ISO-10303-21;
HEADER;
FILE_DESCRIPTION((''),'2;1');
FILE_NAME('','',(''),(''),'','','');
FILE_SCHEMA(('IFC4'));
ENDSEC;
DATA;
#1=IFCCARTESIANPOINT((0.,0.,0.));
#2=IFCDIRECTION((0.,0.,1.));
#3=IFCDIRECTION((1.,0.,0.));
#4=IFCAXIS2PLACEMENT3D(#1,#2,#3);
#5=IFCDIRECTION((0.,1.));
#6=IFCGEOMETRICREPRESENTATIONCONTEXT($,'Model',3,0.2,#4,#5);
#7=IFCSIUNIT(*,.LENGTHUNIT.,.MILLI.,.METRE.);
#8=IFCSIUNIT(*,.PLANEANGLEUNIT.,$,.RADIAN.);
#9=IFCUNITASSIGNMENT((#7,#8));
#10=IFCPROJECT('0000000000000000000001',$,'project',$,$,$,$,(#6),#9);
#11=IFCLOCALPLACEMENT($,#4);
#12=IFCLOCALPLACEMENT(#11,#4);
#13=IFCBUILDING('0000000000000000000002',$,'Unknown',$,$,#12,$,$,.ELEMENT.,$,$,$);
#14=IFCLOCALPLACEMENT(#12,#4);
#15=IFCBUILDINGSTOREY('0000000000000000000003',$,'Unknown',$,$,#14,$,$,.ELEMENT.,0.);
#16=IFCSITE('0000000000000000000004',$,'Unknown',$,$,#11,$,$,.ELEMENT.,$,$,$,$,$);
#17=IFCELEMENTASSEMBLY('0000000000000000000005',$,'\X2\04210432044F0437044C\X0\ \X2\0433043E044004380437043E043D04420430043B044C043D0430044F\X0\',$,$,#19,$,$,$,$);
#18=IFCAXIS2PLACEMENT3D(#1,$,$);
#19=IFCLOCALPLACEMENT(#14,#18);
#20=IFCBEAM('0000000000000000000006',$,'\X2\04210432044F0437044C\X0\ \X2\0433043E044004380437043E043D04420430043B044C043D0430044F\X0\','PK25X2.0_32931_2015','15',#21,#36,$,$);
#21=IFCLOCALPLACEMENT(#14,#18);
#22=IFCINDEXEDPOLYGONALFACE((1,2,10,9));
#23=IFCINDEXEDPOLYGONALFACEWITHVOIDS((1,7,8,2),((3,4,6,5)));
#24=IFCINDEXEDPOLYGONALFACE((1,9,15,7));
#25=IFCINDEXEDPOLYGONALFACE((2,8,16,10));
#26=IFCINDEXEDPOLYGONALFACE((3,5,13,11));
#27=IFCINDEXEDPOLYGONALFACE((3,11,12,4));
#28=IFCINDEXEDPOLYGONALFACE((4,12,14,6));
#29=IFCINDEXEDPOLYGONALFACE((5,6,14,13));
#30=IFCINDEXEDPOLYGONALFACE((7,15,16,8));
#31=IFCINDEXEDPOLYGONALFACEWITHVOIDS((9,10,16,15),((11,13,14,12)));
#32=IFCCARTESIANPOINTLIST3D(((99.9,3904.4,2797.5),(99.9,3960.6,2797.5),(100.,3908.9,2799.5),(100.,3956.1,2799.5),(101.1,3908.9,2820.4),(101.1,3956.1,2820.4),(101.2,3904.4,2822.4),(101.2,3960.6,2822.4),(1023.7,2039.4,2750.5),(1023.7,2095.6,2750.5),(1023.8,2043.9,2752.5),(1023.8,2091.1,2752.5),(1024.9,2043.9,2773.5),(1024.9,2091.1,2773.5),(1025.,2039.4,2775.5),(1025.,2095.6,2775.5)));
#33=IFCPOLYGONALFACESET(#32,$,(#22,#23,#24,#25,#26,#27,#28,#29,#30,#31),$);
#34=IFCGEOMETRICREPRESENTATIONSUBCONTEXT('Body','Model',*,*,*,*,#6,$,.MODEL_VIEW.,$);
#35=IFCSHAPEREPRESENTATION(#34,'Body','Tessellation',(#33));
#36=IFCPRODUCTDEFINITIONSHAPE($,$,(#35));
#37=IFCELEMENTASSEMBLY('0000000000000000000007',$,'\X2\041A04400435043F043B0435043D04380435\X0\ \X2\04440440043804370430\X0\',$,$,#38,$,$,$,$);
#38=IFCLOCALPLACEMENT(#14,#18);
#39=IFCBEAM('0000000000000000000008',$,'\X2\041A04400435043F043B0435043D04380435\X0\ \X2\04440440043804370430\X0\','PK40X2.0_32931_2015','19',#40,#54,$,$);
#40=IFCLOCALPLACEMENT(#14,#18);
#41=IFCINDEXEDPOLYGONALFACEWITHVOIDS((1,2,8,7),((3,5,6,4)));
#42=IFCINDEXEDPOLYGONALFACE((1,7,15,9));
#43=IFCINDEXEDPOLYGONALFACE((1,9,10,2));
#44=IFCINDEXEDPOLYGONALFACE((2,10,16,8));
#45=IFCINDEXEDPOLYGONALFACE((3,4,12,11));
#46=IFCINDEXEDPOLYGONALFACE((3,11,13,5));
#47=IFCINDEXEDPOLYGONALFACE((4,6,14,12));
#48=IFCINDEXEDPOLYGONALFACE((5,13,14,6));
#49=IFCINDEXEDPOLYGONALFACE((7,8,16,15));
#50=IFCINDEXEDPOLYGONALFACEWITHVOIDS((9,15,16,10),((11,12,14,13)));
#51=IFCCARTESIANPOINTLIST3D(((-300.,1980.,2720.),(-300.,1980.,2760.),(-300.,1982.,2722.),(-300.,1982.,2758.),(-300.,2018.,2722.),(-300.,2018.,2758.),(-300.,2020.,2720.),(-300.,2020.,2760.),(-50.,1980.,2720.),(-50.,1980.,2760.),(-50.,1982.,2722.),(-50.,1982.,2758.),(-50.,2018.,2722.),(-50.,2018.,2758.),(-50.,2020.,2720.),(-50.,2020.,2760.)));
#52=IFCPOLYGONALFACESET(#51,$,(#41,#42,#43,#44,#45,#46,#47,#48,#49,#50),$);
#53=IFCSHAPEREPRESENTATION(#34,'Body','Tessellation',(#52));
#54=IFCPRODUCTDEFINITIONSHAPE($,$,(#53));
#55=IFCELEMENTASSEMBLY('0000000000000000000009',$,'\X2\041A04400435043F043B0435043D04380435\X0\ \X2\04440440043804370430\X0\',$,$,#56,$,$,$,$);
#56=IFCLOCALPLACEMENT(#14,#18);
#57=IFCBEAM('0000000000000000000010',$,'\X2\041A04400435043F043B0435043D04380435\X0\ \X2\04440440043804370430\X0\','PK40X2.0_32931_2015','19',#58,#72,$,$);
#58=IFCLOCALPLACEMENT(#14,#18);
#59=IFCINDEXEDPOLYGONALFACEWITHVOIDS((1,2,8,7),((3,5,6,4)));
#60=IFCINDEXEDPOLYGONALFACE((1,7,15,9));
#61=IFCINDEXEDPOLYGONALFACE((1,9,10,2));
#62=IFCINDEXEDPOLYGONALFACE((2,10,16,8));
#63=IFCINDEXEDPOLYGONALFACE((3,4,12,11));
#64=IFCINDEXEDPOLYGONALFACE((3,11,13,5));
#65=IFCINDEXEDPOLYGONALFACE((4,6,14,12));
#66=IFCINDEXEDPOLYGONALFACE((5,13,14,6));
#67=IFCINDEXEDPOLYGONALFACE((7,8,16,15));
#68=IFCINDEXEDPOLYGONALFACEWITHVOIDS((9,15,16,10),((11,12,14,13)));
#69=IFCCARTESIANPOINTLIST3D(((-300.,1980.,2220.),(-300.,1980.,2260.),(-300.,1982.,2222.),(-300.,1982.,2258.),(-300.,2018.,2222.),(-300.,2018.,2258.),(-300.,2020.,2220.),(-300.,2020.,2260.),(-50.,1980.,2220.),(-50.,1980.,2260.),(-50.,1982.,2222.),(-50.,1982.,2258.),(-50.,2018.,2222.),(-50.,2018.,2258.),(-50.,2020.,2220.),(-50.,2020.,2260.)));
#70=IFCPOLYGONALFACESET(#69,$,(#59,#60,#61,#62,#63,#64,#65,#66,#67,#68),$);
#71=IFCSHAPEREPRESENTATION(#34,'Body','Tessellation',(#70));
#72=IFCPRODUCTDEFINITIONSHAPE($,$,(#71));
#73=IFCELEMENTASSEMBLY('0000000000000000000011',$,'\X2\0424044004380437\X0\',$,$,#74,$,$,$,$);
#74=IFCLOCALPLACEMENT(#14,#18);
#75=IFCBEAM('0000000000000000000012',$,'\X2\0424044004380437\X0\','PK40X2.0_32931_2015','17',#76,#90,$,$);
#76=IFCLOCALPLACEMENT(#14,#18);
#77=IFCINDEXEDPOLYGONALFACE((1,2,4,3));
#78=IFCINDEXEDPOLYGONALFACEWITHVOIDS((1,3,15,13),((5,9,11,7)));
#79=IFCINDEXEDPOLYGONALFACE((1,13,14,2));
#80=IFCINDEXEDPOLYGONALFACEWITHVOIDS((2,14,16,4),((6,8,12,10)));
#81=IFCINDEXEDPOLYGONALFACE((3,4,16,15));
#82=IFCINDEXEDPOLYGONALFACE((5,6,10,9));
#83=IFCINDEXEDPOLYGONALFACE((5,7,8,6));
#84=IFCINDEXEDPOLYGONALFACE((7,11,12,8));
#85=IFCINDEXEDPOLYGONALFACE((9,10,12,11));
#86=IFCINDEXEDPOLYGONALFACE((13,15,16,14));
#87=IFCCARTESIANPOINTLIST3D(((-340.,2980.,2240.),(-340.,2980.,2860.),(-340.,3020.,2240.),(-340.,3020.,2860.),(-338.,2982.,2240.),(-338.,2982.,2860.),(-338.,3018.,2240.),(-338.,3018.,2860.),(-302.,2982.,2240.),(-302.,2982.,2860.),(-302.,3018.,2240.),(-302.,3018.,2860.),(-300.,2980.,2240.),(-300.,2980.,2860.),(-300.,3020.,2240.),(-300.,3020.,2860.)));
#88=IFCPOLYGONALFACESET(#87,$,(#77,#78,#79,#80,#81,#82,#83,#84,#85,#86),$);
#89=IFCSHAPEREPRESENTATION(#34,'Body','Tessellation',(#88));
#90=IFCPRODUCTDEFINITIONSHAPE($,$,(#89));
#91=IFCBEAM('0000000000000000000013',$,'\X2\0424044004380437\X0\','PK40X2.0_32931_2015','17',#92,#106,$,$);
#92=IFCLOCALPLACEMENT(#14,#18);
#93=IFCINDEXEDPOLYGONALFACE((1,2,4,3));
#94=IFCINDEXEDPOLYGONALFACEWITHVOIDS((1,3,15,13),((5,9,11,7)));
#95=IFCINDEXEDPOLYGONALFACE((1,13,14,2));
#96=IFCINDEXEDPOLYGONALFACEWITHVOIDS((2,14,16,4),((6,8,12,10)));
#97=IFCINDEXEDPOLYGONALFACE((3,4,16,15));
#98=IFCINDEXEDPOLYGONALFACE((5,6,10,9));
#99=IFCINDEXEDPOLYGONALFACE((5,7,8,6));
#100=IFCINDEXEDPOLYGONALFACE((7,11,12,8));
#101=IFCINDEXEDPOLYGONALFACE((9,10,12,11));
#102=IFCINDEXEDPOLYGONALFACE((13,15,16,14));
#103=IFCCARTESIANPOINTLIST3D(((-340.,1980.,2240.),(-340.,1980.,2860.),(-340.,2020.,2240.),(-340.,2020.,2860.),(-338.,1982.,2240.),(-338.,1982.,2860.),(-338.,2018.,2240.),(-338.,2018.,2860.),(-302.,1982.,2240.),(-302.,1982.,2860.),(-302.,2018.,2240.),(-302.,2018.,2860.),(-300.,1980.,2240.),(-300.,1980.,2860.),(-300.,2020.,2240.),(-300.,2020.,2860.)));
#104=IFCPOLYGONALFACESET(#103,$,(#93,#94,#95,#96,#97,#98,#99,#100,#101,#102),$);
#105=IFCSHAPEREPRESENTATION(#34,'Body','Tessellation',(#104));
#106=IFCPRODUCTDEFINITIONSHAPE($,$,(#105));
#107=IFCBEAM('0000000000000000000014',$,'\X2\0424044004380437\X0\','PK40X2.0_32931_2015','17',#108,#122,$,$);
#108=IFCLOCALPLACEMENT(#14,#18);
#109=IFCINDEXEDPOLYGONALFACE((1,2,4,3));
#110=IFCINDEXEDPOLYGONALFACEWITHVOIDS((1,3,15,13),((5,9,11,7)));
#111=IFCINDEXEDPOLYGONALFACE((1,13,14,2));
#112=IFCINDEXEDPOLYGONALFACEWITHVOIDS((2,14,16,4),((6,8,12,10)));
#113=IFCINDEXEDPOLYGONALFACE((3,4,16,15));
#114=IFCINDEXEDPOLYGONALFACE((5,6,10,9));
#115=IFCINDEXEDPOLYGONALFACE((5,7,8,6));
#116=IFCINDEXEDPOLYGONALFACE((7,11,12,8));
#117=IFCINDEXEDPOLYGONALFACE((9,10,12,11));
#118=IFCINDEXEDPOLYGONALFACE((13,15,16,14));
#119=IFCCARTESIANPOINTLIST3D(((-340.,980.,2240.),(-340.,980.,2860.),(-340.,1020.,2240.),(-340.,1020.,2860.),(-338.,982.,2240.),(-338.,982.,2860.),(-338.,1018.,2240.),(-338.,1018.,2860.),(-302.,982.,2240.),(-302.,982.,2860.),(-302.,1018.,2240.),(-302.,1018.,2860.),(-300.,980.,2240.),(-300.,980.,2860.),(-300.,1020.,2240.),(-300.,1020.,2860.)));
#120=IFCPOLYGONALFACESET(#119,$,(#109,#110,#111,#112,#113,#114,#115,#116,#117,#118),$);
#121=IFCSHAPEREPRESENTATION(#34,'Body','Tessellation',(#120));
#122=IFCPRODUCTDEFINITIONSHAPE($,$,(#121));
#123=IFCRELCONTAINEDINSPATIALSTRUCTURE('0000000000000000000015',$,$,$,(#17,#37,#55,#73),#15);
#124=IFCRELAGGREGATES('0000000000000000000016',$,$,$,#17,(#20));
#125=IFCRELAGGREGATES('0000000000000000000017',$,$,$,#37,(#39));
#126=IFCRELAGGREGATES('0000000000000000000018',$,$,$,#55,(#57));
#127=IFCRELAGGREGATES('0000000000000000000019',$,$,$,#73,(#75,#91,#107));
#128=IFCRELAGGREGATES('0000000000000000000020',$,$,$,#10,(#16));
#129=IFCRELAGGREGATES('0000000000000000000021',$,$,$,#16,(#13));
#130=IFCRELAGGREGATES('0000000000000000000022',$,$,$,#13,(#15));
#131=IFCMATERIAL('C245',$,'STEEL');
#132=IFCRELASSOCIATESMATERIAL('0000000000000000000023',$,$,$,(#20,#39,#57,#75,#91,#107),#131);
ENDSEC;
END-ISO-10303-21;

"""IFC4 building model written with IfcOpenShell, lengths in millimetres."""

from ifc_helpers import new_model, si_unit, direction, frame, origin_with_axes, place, context, subcontext, project, spatial, line, indexed_curve, outline, extrude, material, element, aggregate, save


model = new_model("IFC4")

# Units and contexts
model_context = context("Model", 3, precision=0.2, world=origin_with_axes(), true_north=direction((0.0, 1.0)))
body_context = subcontext(model_context, "Body", "Model", "MODEL_VIEW")
ifc_project = project(units=[si_unit("LENGTHUNIT", "METRE", prefix="MILLI"), si_unit("PLANEANGLEUNIT", "RADIAN")], contexts=[model_context])

# Site, building, storey
site_placement = place(None, origin_with_axes())
site = spatial("IfcSite", under=ifc_project, at=site_placement, Name="Unknown", CompositionType="ELEMENT")
building_placement = place(site_placement, origin_with_axes())
building = spatial("IfcBuilding", under=site, at=building_placement, Name="Unknown", CompositionType="ELEMENT")
storey_placement = place(building_placement, origin_with_axes())
storey = spatial("IfcBuildingStorey", under=building, at=storey_placement, Name="Unknown", CompositionType="ELEMENT", Elevation=0.0)

# Shared definitions
ifc_material_1 = material(Name="C245", Category="STEEL")

# Element assembly, beam, voiding features
assembly_1_placement = place(storey_placement, frame((73.4, 3987.4, 2811.3), z_axis=(-0.894709, -0.444326, 0.045494), x_axis=(0.443753, -0.895865, -0.022564)))
assembly_1 = element("IfcElementAssembly", 1, at=assembly_1_placement, inside=storey, Name="Связь горизонтальная")
beam_1_placement = place(assembly_1_placement, origin_with_axes())
beam_1 = element("IfcBeam", 2, at=beam_1_placement, material=ifc_material_1, Name="Связь горизонтальная", Description="PK25X2.0_32931_2015", ObjectType="15", context=body_context, shape_type="SolidModel", body=[
    extrude(outline(indexed_curve([(-12.5, -12.5), (12.5, -12.5), (12.5, 12.5), (-12.5, 12.5)], segments=[line(1, 2, 3, 4, 1)]), holes=[indexed_curve([(-10.5, -10.5), (-10.5, 10.5), (10.5, 10.5), (10.5, -10.5)], segments=[line(1, 2, 3, 4, 1)])]), frame((0.0, 0.0, 0.0), z_axis=(-1.0, 0.0, 0.0), x_axis=(0.0, 0.0, 1.0)), (0.0, 0.0, -1.0), 2204.4),
])
voiding_feature_1_placement = place(beam_1_placement, frame((3193.8, 12.5, 493.2), z_axis=(0.444326, 0.0, -0.895865), x_axis=(-0.895865, 0.0, -0.444326)))
element("IfcVoidingFeature", 3, at=voiding_feature_1_placement, cuts=beam_1, Name="CUT_BEAM", ObjectType="(?)", PredefinedType="HOLE", context=body_context, shape_type="SolidModel", body=[
    extrude(outline(indexed_curve([(-25.0, -25.0), (25.0, -25.0), (25.0, 25.0), (-25.0, 25.0)], segments=[line(1, 2, 3, 4, 1)])), frame((0.0, 0.0, 0.0), z_axis=(-1.0, 0.0, 0.0), x_axis=(0.0, 0.0, 1.0)), (0.0, 0.0, -1.0), 2220.1),
])
voiding_feature_2_placement = place(beam_1_placement, frame((999.5, 12.5, 493.2), z_axis=(0.444326, 0.0, -0.895865), x_axis=(-0.895865, 0.0, -0.444326)))
element("IfcVoidingFeature", 4, at=voiding_feature_2_placement, cuts=beam_1, Name="CUT_BEAM", ObjectType="(?)", PredefinedType="HOLE", context=body_context, shape_type="SolidModel", body=[
    extrude(outline(indexed_curve([(-25.0, -25.0), (25.0, -25.0), (25.0, 25.0), (-25.0, 25.0)], segments=[line(1, 2, 3, 4, 1)])), frame((0.0, 0.0, 0.0), z_axis=(-1.0, 0.0, 0.0), x_axis=(0.0, 0.0, 1.0)), (0.0, 0.0, -1.0), 2220.1),
])
aggregate(assembly_1, [beam_1])

# Element assemblies, beams
assembly_2_placement = place(storey_placement, frame((-300.0, 2000.0, 2740.0), z_axis=(0.0, 1.0, 0.0), x_axis=(1.0, 0.0, 0.0)))
assembly_2 = element("IfcElementAssembly", 5, at=assembly_2_placement, inside=storey, Name="Крепление фриза")
beam_2_placement = place(assembly_2_placement, origin_with_axes())
beam_2 = element("IfcBeam", 6, at=beam_2_placement, material=ifc_material_1, Name="Крепление фриза", Description="PK40X2.0_32931_2015", ObjectType="19", context=body_context, shape_type="SolidModel", body=[
    extrude(outline(indexed_curve([(-20.0, -20.0), (20.0, -20.0), (20.0, 20.0), (-20.0, 20.0)], segments=[line(1, 2, 3, 4, 1)]), holes=[indexed_curve([(-18.0, -18.0), (-18.0, 18.0), (18.0, 18.0), (18.0, -18.0)], segments=[line(1, 2, 3, 4, 1)])]), frame((0.0, 0.0, 0.0), z_axis=(-1.0, 0.0, 0.0), x_axis=(0.0, 0.0, 1.0)), (0.0, 0.0, -1.0), 250.0),
])
aggregate(assembly_2, [beam_2])
assembly_3_placement = place(storey_placement, frame((-300.0, 2000.0, 2240.0), z_axis=(0.0, 1.0, 0.0), x_axis=(1.0, 0.0, 0.0)))
assembly_3 = element("IfcElementAssembly", 7, at=assembly_3_placement, inside=storey, Name="Крепление фриза")
beam_3_placement = place(assembly_3_placement, origin_with_axes())
beam_3 = element("IfcBeam", 8, at=beam_3_placement, material=ifc_material_1, Name="Крепление фриза", Description="PK40X2.0_32931_2015", ObjectType="19", context=body_context, shape_type="SolidModel", body=[
    extrude(outline(indexed_curve([(-20.0, -20.0), (20.0, -20.0), (20.0, 20.0), (-20.0, 20.0)], segments=[line(1, 2, 3, 4, 1)]), holes=[indexed_curve([(-18.0, -18.0), (-18.0, 18.0), (18.0, 18.0), (18.0, -18.0)], segments=[line(1, 2, 3, 4, 1)])]), frame((0.0, 0.0, 0.0), z_axis=(-1.0, 0.0, 0.0), x_axis=(0.0, 0.0, 1.0)), (0.0, 0.0, -1.0), 250.0),
])
aggregate(assembly_3, [beam_3])

# Element assembly, beams
assembly_4_placement = place(storey_placement, frame((-320.0, -300.0, 2880.0), z_axis=(1.0, 0.0, 0.0), x_axis=(0.0, 1.0, 0.0)))
assembly_4 = element("IfcElementAssembly", 9, at=assembly_4_placement, inside=storey, Name="Фриз")
beam_4_placement = place(assembly_4_placement, frame((3300.0, -20.0, 0.0), z_axis=(-1.0, 0.0, 0.0), x_axis=(0.0, -1.0, 0.0)))
beam_4 = element("IfcBeam", 10, at=beam_4_placement, material=ifc_material_1, Name="Фриз", Description="PK40X2.0_32931_2015", ObjectType="17", context=body_context, shape_type="SolidModel", body=[
    extrude(outline(indexed_curve([(-20.0, -20.0), (20.0, -20.0), (20.0, 20.0), (-20.0, 20.0)], segments=[line(1, 2, 3, 4, 1)]), holes=[indexed_curve([(-18.0, -18.0), (-18.0, 18.0), (18.0, 18.0), (18.0, -18.0)], segments=[line(1, 2, 3, 4, 1)])]), frame((0.0, 0.0, 0.0), z_axis=(-1.0, 0.0, 0.0), x_axis=(0.0, 0.0, 1.0)), (0.0, 0.0, -1.0), 620.0),
])
beam_5_placement = place(assembly_4_placement, frame((2300.0, -20.0, 0.0), z_axis=(-1.0, 0.0, 0.0), x_axis=(0.0, -1.0, 0.0)))
beam_5 = element("IfcBeam", 11, at=beam_5_placement, material=ifc_material_1, Name="Фриз", Description="PK40X2.0_32931_2015", ObjectType="17", context=body_context, shape_type="SolidModel", body=[
    extrude(outline(indexed_curve([(-20.0, -20.0), (20.0, -20.0), (20.0, 20.0), (-20.0, 20.0)], segments=[line(1, 2, 3, 4, 1)]), holes=[indexed_curve([(-18.0, -18.0), (-18.0, 18.0), (18.0, 18.0), (18.0, -18.0)], segments=[line(1, 2, 3, 4, 1)])]), frame((0.0, 0.0, 0.0), z_axis=(-1.0, 0.0, 0.0), x_axis=(0.0, 0.0, 1.0)), (0.0, 0.0, -1.0), 620.0),
])
beam_6_placement = place(assembly_4_placement, frame((1300.0, -20.0, 0.0), z_axis=(-1.0, 0.0, 0.0), x_axis=(0.0, -1.0, 0.0)))
beam_6 = element("IfcBeam", 12, at=beam_6_placement, material=ifc_material_1, Name="Фриз", Description="PK40X2.0_32931_2015", ObjectType="17", context=body_context, shape_type="SolidModel", body=[
    extrude(outline(indexed_curve([(-20.0, -20.0), (20.0, -20.0), (20.0, 20.0), (-20.0, 20.0)], segments=[line(1, 2, 3, 4, 1)]), holes=[indexed_curve([(-18.0, -18.0), (-18.0, 18.0), (18.0, 18.0), (18.0, -18.0)], segments=[line(1, 2, 3, 4, 1)])]), frame((0.0, 0.0, 0.0), z_axis=(-1.0, 0.0, 0.0), x_axis=(0.0, 0.0, 1.0)), (0.0, 0.0, -1.0), 620.0),
])
aggregate(assembly_4, [beam_4, beam_5, beam_6])

save(model, "model.ifc")
